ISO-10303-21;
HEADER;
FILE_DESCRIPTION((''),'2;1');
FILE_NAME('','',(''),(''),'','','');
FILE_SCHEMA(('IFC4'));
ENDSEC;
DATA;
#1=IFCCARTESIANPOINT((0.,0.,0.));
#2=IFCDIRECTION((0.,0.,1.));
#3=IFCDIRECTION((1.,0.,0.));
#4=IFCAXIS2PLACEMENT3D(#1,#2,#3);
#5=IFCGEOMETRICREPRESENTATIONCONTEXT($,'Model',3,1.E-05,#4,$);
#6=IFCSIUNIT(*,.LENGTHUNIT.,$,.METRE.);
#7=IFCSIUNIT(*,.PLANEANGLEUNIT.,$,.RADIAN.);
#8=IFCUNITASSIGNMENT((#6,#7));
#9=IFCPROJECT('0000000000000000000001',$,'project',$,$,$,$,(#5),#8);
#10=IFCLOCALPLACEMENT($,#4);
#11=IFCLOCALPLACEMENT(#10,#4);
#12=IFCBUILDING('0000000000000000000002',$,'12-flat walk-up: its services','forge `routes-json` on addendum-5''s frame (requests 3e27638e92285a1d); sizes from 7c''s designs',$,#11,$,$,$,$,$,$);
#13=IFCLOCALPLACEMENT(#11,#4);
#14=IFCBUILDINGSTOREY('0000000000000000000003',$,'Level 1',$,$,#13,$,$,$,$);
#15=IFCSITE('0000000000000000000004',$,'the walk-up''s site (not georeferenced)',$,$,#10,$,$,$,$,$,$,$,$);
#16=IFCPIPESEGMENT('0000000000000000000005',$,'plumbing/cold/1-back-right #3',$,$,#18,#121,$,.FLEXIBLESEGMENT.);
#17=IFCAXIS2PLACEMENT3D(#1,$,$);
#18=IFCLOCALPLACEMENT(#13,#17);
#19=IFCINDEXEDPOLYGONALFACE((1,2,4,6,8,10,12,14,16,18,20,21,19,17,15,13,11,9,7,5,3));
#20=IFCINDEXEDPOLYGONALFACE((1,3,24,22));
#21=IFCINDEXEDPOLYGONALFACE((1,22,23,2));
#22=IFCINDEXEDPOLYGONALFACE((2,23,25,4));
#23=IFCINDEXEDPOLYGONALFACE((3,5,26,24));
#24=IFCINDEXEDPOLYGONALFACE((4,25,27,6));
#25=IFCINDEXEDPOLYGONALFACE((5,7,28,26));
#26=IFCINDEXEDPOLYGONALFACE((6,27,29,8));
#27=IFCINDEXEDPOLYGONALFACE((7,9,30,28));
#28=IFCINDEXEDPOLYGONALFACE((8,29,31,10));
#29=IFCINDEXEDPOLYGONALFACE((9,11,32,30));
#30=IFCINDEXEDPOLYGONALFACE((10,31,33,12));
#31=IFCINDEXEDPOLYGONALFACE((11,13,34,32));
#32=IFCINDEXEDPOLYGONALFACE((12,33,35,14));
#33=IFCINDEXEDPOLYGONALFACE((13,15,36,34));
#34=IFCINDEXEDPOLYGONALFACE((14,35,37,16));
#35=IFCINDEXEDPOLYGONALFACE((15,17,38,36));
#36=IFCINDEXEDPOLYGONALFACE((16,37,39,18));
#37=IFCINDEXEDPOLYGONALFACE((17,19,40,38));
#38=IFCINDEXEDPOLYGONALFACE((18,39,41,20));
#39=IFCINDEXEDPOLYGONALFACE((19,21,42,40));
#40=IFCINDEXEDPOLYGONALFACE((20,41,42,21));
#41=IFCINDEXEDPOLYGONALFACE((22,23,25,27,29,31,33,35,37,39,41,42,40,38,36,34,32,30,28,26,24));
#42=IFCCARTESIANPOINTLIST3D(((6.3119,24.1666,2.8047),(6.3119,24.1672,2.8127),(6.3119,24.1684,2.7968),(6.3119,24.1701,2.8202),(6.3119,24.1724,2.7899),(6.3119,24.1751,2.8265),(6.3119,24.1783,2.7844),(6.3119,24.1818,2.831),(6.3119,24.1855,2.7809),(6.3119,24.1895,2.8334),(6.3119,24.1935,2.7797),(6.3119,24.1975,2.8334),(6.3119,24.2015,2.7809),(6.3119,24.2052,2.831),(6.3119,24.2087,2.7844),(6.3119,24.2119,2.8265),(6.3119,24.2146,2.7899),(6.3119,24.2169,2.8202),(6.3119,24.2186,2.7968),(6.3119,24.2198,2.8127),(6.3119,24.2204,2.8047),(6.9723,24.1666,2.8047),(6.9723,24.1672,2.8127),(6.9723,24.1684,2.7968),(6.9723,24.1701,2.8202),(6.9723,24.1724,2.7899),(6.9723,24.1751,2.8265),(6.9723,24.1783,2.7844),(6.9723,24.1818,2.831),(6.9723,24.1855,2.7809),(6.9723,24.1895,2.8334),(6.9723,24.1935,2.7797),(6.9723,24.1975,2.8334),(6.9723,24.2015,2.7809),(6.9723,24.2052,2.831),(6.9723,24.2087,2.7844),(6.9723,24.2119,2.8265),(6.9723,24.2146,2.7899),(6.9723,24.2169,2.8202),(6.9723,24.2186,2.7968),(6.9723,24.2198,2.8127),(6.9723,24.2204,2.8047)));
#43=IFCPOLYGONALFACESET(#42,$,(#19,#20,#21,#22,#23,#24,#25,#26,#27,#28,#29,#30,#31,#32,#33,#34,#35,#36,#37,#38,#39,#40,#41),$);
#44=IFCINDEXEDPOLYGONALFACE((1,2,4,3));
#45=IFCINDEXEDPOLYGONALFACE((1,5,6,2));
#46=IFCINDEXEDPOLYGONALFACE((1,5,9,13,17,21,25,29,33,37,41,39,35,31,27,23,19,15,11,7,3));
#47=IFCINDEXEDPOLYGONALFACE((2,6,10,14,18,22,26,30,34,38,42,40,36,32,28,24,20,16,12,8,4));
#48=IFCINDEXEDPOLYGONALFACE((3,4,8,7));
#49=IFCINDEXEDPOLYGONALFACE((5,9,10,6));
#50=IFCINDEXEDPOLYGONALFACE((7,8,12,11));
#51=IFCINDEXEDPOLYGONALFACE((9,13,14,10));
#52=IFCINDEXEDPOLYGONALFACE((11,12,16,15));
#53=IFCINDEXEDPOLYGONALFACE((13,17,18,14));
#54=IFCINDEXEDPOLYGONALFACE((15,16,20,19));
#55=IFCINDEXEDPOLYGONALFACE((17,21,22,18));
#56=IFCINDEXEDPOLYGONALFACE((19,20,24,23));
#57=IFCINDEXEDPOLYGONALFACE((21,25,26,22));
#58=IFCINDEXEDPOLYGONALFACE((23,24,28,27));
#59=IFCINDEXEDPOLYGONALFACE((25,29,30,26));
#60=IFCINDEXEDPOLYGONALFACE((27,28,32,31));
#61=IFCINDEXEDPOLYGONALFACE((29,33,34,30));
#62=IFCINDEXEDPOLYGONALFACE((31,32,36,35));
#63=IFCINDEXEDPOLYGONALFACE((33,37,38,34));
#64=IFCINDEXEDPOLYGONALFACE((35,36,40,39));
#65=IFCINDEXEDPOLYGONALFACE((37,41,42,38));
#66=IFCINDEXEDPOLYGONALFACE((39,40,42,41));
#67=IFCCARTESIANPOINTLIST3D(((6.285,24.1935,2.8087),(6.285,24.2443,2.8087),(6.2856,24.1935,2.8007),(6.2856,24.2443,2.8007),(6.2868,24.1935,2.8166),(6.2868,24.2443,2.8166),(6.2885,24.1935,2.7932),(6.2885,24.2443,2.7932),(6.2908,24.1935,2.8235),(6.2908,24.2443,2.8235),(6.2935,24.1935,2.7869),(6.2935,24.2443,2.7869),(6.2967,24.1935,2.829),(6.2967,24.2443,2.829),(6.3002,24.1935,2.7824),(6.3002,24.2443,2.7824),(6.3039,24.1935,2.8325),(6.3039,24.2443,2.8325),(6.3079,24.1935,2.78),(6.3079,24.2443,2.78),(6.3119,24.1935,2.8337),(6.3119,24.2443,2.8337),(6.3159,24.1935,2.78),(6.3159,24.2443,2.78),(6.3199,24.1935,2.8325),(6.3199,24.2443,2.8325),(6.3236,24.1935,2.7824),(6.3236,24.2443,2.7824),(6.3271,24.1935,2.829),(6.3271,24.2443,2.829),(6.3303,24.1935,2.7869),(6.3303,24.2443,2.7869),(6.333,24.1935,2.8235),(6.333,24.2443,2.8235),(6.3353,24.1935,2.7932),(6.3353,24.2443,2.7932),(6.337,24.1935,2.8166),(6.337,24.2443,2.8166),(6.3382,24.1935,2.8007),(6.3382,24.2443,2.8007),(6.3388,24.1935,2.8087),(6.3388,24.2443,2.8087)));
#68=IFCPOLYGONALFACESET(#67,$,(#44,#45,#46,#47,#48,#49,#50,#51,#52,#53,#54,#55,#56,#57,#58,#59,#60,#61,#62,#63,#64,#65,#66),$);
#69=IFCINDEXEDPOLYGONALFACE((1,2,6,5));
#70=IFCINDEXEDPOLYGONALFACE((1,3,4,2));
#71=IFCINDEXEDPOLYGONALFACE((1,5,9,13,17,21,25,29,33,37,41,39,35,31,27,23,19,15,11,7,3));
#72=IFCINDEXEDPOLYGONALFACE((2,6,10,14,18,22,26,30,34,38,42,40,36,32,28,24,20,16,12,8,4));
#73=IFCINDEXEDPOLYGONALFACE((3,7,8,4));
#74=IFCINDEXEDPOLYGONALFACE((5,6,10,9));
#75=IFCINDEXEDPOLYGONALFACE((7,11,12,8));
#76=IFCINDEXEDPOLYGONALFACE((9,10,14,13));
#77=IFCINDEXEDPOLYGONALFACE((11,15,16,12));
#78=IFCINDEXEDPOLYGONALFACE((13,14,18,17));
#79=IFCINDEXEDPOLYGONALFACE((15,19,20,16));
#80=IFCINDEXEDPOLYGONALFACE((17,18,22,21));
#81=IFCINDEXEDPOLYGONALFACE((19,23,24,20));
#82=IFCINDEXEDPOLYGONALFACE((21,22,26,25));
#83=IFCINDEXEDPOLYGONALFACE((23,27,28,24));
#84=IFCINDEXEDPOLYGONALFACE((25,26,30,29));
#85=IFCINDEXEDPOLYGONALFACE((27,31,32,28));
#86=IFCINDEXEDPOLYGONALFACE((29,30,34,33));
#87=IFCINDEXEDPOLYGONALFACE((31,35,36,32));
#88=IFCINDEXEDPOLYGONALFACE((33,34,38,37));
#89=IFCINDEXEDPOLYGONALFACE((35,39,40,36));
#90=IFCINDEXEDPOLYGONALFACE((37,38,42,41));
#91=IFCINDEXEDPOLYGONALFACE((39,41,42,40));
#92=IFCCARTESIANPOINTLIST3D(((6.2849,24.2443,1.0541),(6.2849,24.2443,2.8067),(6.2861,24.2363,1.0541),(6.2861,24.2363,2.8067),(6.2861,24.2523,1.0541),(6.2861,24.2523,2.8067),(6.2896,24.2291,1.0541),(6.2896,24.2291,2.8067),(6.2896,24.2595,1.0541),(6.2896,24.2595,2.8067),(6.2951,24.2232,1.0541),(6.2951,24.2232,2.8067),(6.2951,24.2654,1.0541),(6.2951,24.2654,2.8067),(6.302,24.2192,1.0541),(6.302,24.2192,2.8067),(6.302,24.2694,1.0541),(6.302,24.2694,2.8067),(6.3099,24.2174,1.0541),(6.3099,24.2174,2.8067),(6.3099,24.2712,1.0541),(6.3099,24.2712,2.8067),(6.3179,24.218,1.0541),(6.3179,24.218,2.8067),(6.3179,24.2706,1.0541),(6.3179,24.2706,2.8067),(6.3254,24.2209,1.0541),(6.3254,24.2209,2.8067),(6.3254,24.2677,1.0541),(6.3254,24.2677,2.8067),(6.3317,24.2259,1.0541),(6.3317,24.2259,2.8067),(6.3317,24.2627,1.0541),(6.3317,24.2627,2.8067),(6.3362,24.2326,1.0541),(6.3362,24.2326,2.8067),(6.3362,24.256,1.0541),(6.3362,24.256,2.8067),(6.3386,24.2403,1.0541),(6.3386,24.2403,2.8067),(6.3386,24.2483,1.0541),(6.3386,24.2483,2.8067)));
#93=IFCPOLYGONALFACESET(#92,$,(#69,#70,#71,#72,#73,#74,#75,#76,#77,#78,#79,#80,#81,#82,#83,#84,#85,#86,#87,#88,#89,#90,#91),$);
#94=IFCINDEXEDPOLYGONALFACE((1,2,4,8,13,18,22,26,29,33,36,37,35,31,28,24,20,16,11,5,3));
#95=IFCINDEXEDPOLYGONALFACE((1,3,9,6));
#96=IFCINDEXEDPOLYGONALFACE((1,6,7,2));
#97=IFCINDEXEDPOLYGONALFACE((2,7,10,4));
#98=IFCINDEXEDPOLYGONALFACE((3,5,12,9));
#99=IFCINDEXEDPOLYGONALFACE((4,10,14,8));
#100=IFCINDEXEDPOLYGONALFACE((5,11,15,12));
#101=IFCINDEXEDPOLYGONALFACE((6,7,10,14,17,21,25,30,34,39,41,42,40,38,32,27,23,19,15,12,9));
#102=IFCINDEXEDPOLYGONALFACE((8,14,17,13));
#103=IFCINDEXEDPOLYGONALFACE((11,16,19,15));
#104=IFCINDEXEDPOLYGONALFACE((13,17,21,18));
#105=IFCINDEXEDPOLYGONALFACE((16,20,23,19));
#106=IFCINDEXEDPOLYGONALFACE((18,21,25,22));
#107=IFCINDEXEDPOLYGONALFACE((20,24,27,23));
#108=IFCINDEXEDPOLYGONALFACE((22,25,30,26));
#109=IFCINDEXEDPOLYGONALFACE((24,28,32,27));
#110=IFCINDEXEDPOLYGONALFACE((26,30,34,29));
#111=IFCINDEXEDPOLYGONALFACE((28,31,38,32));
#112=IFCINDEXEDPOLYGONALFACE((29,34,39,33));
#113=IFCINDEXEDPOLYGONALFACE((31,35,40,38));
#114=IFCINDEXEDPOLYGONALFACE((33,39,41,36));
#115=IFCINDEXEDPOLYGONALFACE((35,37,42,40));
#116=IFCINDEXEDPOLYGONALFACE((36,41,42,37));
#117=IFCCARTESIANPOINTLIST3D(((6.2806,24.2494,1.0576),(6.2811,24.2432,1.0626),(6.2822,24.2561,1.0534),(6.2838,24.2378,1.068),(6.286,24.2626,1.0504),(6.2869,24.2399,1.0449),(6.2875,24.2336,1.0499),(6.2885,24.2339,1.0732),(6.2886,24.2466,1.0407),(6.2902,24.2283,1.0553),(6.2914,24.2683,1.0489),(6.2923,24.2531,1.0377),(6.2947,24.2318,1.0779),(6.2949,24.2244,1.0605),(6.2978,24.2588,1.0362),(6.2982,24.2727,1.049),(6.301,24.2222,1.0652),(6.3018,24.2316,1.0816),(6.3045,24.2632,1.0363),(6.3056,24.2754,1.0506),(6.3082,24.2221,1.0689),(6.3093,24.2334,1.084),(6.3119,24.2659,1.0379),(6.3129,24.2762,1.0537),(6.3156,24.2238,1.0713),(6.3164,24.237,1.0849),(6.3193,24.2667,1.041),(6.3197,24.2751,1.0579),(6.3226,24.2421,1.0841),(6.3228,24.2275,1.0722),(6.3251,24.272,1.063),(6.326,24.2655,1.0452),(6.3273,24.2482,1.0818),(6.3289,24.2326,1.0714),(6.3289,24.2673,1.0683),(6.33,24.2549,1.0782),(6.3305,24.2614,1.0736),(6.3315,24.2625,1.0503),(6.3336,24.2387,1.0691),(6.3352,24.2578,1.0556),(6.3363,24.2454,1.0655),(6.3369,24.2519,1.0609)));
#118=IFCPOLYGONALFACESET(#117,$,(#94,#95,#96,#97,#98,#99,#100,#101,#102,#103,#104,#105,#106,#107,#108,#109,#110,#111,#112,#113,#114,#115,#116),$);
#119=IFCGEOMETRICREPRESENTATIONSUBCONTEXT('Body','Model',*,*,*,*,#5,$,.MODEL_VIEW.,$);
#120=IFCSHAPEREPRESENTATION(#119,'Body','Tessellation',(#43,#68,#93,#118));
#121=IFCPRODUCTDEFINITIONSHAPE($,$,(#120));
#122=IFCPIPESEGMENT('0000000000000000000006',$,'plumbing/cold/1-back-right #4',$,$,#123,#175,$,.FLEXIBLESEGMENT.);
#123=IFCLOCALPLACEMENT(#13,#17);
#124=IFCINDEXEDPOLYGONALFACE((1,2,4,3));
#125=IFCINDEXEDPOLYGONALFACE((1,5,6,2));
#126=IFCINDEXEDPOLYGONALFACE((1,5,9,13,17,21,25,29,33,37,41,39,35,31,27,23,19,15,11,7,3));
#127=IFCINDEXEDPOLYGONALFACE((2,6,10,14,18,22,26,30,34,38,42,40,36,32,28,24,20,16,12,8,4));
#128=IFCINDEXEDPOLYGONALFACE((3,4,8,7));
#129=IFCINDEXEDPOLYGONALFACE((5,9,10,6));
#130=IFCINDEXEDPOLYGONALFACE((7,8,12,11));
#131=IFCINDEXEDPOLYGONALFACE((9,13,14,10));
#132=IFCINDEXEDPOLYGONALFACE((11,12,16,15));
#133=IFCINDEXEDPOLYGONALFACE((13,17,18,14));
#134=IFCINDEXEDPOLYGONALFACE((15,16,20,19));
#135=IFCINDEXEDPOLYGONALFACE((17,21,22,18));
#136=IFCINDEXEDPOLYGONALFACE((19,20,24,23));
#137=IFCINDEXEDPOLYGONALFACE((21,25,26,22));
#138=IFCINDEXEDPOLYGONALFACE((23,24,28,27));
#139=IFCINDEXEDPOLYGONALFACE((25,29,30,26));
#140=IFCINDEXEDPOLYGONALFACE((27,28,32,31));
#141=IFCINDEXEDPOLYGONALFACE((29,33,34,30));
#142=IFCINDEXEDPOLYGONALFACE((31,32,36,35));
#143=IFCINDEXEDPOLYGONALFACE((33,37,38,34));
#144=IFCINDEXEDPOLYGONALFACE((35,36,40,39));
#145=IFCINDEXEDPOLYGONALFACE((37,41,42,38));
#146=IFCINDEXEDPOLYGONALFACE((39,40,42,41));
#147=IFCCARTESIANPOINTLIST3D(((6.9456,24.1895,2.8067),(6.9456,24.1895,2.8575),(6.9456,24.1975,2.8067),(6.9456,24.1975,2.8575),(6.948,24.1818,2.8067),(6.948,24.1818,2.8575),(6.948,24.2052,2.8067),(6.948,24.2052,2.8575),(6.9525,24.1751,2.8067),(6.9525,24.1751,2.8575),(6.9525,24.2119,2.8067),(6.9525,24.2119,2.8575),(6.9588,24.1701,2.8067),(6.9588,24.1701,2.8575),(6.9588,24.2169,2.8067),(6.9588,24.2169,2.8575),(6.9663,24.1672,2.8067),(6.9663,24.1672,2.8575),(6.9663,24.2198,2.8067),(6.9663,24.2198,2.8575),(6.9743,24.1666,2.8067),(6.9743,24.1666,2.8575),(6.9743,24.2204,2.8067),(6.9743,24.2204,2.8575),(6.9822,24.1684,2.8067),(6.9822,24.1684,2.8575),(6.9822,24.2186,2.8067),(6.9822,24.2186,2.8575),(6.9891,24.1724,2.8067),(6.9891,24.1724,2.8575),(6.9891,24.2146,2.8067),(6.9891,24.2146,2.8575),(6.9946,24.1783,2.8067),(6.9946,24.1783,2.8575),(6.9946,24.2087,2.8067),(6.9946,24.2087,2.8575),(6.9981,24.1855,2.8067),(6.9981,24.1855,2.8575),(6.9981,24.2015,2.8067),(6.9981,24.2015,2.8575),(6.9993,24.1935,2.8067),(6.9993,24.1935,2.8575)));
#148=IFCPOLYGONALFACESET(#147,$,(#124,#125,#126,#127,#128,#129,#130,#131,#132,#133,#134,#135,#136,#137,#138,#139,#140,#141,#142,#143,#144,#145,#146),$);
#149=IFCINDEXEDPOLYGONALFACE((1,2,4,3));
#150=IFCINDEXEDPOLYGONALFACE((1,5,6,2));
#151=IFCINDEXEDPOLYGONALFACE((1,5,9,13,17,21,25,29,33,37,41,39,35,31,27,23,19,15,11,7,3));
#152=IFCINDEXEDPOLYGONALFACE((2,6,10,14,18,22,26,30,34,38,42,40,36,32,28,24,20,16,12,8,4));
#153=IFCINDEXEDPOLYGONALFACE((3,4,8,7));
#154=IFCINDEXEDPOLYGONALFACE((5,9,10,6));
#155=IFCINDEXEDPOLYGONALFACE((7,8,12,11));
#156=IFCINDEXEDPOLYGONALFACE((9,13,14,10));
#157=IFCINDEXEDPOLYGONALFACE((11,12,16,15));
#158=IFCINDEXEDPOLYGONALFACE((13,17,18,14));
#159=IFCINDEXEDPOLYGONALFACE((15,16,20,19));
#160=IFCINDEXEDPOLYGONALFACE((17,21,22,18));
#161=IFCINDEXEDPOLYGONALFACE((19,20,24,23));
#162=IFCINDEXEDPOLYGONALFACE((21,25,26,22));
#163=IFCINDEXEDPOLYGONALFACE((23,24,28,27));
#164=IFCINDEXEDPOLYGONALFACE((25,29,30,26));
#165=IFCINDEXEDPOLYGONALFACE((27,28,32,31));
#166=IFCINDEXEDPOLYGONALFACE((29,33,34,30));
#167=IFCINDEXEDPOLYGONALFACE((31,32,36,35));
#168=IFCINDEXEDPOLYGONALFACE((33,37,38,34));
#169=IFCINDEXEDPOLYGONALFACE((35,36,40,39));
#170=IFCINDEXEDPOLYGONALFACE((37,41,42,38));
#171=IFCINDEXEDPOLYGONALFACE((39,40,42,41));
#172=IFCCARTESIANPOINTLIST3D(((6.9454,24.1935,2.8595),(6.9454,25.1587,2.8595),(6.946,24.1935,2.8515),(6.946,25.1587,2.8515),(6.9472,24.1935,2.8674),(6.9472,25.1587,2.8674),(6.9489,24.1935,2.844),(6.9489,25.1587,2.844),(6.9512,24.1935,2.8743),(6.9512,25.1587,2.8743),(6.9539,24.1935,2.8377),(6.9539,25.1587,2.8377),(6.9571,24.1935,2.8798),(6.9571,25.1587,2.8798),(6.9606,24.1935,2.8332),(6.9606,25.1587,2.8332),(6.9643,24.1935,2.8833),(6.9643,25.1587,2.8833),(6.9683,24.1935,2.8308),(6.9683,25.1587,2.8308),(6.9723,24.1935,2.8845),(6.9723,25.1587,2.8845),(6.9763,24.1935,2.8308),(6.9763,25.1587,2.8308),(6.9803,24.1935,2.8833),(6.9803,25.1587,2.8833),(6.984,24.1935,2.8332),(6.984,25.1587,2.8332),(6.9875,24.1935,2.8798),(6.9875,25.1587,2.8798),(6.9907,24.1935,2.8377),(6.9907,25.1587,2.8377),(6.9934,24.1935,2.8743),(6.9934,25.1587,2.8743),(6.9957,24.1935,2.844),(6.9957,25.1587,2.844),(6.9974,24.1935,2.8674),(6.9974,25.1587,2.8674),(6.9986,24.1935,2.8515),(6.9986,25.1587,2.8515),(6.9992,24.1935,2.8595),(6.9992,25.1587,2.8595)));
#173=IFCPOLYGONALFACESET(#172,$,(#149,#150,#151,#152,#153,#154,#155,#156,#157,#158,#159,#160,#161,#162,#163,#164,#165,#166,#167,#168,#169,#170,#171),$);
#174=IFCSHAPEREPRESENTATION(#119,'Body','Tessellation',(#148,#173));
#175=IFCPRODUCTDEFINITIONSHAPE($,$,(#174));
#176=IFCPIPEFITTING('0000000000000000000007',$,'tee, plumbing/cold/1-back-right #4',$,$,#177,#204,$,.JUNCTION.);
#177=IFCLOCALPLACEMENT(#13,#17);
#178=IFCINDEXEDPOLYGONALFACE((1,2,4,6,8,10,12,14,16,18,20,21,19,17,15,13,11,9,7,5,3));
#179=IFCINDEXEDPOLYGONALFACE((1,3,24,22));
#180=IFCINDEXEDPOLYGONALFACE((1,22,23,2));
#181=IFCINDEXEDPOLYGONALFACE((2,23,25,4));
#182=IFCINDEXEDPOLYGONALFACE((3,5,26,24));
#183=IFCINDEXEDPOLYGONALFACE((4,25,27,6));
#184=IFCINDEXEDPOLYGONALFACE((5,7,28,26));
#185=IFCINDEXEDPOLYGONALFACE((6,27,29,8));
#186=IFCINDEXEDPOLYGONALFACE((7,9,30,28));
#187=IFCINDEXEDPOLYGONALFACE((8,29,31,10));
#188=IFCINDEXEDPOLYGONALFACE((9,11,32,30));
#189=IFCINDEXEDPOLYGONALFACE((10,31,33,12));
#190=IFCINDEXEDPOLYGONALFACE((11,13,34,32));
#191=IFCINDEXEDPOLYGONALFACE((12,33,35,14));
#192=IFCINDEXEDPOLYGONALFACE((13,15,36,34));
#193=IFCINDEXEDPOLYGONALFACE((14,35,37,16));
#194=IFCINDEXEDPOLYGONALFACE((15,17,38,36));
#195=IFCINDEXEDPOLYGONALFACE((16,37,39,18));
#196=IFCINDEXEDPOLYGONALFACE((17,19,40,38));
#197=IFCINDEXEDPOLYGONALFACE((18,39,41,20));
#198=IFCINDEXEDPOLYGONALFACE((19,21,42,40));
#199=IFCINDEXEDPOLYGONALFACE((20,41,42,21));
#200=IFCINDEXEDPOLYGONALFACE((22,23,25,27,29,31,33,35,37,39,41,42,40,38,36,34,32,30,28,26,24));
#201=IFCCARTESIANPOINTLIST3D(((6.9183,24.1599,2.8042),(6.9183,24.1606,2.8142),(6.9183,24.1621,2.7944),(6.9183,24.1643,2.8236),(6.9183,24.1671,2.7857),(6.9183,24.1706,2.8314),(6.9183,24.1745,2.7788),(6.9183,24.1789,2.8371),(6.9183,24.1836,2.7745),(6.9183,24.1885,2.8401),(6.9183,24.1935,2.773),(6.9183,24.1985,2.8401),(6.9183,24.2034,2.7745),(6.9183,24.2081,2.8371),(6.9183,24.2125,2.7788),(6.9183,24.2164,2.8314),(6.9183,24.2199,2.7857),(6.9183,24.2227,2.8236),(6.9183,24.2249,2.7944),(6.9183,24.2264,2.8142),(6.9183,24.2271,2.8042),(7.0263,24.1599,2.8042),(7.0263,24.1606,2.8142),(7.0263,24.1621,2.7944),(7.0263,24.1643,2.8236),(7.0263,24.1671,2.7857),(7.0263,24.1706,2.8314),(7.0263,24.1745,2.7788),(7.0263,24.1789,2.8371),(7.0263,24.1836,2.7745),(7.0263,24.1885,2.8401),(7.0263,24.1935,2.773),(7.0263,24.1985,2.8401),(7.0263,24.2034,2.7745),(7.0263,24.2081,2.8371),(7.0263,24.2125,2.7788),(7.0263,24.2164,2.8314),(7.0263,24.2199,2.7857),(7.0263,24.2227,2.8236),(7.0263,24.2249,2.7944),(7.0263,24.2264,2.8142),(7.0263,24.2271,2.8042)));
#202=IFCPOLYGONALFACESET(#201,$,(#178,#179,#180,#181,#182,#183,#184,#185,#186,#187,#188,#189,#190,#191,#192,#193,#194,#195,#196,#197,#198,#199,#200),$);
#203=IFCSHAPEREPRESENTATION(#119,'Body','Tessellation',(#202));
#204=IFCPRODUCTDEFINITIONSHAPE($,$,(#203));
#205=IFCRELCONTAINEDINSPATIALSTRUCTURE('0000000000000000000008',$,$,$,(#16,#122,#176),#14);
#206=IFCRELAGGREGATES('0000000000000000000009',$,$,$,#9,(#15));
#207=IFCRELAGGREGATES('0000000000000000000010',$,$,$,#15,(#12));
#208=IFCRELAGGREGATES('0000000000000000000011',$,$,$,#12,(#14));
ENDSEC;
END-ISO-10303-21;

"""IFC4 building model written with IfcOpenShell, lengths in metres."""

from ifc_helpers import new_model, entity, si_unit, frame, origin_with_axes, place, context, subcontext, project, spatial, element, save


model = new_model("IFC4")

# Units and contexts
model_context = context("Model", 3, precision=1e-05, world=origin_with_axes())
body_context = subcontext(model_context, "Body", "Model", "MODEL_VIEW")
ifc_project = project(units=[si_unit("LENGTHUNIT", "METRE"), si_unit("PLANEANGLEUNIT", "RADIAN")], contexts=[model_context])

# Site, building, storey
site_placement = place(None, origin_with_axes())
site = spatial("IfcSite", under=ifc_project, at=site_placement, Name="the walk-up's site (not georeferenced)")
building_placement = place(site_placement, origin_with_axes())
building = spatial("IfcBuilding", under=site, at=building_placement, Name="12-flat walk-up: its services", Description="forge `routes-json` on addendum-5's frame (requests 3e27638e92285a1d); sizes from 7c's designs")
storey_placement = place(building_placement, origin_with_axes())
storey = spatial("IfcBuildingStorey", under=building, at=storey_placement, Name="Level 1")

# Pipe segments
pipe_segment_1_placement = place(storey_placement, frame((6.9723, 24.1935, 2.8067), z_axis=(0.0, 0.0, 1.0), x_axis=(1.0, 0.0, 0.0)))
element("IfcPipeSegment", 1, at=pipe_segment_1_placement, inside=storey, Name="plumbing/cold/1-back-right #3", PredefinedType="FLEXIBLESEGMENT", context=body_context, shape_type="AdvancedSweptSolid", body=[
    entity("IfcSweptDiskSolid", entity("IfcPolyline", [entity("IfcCartesianPoint", [0.0, 0.0, 0.0]), entity("IfcCartesianPoint", [-0.6604, 0.0, 0.0])]), 0.027),
    entity("IfcSweptDiskSolid", entity("IfcPolyline", [entity("IfcCartesianPoint", [-0.6604, 0.0, 0.0]), entity("IfcCartesianPoint", [-0.6604, 0.0508, 0.0])]), 0.027),
    entity("IfcSweptDiskSolid", entity("IfcPolyline", [entity("IfcCartesianPoint", [-0.6604, 0.0508, 0.0]), entity("IfcCartesianPoint", [-0.6604, 0.0508, -1.7526])]), 0.027),
    entity("IfcSweptDiskSolid", entity("IfcPolyline", [entity("IfcCartesianPoint", [-0.6604, 0.0508, -1.7526]), entity("IfcCartesianPoint", [-0.6667, 0.0603, -1.7399])]), 0.027),
])
pipe_segment_2_placement = place(storey_placement, frame((6.9723, 24.1935, 2.8067), z_axis=(0.0, 0.0, 1.0), x_axis=(1.0, 0.0, 0.0)))
element("IfcPipeSegment", 2, at=pipe_segment_2_placement, inside=storey, Name="plumbing/cold/1-back-right #4", PredefinedType="FLEXIBLESEGMENT", context=body_context, shape_type="AdvancedSweptSolid", body=[
    entity("IfcSweptDiskSolid", entity("IfcPolyline", [entity("IfcCartesianPoint", [0.0, 0.0, 0.0]), entity("IfcCartesianPoint", [0.0, 0.0, 0.0508])]), 0.027),
    entity("IfcSweptDiskSolid", entity("IfcPolyline", [entity("IfcCartesianPoint", [0.0, 0.0, 0.0508]), entity("IfcCartesianPoint", [0.0, 0.9652, 0.0508])]), 0.027),
])

# Pipe fitting
pipe_fitting_1_placement = place(storey_placement, frame((7.0263, 24.1935, 2.8067), z_axis=(0.0, 0.0, 1.0), x_axis=(1.0, 0.0, 0.0)))
element("IfcPipeFitting", 3, at=pipe_fitting_1_placement, inside=storey, Name="tee, plumbing/cold/1-back-right #4", PredefinedType="JUNCTION", context=body_context, shape_type="AdvancedSweptSolid", body=[
    entity("IfcSweptDiskSolid", entity("IfcPolyline", [entity("IfcCartesianPoint", [0.0, 0.0, 0.0]), entity("IfcCartesianPoint", [-0.108, 0.0, 0.0])]), 0.0337),
])

save(model, "model.ifc")
